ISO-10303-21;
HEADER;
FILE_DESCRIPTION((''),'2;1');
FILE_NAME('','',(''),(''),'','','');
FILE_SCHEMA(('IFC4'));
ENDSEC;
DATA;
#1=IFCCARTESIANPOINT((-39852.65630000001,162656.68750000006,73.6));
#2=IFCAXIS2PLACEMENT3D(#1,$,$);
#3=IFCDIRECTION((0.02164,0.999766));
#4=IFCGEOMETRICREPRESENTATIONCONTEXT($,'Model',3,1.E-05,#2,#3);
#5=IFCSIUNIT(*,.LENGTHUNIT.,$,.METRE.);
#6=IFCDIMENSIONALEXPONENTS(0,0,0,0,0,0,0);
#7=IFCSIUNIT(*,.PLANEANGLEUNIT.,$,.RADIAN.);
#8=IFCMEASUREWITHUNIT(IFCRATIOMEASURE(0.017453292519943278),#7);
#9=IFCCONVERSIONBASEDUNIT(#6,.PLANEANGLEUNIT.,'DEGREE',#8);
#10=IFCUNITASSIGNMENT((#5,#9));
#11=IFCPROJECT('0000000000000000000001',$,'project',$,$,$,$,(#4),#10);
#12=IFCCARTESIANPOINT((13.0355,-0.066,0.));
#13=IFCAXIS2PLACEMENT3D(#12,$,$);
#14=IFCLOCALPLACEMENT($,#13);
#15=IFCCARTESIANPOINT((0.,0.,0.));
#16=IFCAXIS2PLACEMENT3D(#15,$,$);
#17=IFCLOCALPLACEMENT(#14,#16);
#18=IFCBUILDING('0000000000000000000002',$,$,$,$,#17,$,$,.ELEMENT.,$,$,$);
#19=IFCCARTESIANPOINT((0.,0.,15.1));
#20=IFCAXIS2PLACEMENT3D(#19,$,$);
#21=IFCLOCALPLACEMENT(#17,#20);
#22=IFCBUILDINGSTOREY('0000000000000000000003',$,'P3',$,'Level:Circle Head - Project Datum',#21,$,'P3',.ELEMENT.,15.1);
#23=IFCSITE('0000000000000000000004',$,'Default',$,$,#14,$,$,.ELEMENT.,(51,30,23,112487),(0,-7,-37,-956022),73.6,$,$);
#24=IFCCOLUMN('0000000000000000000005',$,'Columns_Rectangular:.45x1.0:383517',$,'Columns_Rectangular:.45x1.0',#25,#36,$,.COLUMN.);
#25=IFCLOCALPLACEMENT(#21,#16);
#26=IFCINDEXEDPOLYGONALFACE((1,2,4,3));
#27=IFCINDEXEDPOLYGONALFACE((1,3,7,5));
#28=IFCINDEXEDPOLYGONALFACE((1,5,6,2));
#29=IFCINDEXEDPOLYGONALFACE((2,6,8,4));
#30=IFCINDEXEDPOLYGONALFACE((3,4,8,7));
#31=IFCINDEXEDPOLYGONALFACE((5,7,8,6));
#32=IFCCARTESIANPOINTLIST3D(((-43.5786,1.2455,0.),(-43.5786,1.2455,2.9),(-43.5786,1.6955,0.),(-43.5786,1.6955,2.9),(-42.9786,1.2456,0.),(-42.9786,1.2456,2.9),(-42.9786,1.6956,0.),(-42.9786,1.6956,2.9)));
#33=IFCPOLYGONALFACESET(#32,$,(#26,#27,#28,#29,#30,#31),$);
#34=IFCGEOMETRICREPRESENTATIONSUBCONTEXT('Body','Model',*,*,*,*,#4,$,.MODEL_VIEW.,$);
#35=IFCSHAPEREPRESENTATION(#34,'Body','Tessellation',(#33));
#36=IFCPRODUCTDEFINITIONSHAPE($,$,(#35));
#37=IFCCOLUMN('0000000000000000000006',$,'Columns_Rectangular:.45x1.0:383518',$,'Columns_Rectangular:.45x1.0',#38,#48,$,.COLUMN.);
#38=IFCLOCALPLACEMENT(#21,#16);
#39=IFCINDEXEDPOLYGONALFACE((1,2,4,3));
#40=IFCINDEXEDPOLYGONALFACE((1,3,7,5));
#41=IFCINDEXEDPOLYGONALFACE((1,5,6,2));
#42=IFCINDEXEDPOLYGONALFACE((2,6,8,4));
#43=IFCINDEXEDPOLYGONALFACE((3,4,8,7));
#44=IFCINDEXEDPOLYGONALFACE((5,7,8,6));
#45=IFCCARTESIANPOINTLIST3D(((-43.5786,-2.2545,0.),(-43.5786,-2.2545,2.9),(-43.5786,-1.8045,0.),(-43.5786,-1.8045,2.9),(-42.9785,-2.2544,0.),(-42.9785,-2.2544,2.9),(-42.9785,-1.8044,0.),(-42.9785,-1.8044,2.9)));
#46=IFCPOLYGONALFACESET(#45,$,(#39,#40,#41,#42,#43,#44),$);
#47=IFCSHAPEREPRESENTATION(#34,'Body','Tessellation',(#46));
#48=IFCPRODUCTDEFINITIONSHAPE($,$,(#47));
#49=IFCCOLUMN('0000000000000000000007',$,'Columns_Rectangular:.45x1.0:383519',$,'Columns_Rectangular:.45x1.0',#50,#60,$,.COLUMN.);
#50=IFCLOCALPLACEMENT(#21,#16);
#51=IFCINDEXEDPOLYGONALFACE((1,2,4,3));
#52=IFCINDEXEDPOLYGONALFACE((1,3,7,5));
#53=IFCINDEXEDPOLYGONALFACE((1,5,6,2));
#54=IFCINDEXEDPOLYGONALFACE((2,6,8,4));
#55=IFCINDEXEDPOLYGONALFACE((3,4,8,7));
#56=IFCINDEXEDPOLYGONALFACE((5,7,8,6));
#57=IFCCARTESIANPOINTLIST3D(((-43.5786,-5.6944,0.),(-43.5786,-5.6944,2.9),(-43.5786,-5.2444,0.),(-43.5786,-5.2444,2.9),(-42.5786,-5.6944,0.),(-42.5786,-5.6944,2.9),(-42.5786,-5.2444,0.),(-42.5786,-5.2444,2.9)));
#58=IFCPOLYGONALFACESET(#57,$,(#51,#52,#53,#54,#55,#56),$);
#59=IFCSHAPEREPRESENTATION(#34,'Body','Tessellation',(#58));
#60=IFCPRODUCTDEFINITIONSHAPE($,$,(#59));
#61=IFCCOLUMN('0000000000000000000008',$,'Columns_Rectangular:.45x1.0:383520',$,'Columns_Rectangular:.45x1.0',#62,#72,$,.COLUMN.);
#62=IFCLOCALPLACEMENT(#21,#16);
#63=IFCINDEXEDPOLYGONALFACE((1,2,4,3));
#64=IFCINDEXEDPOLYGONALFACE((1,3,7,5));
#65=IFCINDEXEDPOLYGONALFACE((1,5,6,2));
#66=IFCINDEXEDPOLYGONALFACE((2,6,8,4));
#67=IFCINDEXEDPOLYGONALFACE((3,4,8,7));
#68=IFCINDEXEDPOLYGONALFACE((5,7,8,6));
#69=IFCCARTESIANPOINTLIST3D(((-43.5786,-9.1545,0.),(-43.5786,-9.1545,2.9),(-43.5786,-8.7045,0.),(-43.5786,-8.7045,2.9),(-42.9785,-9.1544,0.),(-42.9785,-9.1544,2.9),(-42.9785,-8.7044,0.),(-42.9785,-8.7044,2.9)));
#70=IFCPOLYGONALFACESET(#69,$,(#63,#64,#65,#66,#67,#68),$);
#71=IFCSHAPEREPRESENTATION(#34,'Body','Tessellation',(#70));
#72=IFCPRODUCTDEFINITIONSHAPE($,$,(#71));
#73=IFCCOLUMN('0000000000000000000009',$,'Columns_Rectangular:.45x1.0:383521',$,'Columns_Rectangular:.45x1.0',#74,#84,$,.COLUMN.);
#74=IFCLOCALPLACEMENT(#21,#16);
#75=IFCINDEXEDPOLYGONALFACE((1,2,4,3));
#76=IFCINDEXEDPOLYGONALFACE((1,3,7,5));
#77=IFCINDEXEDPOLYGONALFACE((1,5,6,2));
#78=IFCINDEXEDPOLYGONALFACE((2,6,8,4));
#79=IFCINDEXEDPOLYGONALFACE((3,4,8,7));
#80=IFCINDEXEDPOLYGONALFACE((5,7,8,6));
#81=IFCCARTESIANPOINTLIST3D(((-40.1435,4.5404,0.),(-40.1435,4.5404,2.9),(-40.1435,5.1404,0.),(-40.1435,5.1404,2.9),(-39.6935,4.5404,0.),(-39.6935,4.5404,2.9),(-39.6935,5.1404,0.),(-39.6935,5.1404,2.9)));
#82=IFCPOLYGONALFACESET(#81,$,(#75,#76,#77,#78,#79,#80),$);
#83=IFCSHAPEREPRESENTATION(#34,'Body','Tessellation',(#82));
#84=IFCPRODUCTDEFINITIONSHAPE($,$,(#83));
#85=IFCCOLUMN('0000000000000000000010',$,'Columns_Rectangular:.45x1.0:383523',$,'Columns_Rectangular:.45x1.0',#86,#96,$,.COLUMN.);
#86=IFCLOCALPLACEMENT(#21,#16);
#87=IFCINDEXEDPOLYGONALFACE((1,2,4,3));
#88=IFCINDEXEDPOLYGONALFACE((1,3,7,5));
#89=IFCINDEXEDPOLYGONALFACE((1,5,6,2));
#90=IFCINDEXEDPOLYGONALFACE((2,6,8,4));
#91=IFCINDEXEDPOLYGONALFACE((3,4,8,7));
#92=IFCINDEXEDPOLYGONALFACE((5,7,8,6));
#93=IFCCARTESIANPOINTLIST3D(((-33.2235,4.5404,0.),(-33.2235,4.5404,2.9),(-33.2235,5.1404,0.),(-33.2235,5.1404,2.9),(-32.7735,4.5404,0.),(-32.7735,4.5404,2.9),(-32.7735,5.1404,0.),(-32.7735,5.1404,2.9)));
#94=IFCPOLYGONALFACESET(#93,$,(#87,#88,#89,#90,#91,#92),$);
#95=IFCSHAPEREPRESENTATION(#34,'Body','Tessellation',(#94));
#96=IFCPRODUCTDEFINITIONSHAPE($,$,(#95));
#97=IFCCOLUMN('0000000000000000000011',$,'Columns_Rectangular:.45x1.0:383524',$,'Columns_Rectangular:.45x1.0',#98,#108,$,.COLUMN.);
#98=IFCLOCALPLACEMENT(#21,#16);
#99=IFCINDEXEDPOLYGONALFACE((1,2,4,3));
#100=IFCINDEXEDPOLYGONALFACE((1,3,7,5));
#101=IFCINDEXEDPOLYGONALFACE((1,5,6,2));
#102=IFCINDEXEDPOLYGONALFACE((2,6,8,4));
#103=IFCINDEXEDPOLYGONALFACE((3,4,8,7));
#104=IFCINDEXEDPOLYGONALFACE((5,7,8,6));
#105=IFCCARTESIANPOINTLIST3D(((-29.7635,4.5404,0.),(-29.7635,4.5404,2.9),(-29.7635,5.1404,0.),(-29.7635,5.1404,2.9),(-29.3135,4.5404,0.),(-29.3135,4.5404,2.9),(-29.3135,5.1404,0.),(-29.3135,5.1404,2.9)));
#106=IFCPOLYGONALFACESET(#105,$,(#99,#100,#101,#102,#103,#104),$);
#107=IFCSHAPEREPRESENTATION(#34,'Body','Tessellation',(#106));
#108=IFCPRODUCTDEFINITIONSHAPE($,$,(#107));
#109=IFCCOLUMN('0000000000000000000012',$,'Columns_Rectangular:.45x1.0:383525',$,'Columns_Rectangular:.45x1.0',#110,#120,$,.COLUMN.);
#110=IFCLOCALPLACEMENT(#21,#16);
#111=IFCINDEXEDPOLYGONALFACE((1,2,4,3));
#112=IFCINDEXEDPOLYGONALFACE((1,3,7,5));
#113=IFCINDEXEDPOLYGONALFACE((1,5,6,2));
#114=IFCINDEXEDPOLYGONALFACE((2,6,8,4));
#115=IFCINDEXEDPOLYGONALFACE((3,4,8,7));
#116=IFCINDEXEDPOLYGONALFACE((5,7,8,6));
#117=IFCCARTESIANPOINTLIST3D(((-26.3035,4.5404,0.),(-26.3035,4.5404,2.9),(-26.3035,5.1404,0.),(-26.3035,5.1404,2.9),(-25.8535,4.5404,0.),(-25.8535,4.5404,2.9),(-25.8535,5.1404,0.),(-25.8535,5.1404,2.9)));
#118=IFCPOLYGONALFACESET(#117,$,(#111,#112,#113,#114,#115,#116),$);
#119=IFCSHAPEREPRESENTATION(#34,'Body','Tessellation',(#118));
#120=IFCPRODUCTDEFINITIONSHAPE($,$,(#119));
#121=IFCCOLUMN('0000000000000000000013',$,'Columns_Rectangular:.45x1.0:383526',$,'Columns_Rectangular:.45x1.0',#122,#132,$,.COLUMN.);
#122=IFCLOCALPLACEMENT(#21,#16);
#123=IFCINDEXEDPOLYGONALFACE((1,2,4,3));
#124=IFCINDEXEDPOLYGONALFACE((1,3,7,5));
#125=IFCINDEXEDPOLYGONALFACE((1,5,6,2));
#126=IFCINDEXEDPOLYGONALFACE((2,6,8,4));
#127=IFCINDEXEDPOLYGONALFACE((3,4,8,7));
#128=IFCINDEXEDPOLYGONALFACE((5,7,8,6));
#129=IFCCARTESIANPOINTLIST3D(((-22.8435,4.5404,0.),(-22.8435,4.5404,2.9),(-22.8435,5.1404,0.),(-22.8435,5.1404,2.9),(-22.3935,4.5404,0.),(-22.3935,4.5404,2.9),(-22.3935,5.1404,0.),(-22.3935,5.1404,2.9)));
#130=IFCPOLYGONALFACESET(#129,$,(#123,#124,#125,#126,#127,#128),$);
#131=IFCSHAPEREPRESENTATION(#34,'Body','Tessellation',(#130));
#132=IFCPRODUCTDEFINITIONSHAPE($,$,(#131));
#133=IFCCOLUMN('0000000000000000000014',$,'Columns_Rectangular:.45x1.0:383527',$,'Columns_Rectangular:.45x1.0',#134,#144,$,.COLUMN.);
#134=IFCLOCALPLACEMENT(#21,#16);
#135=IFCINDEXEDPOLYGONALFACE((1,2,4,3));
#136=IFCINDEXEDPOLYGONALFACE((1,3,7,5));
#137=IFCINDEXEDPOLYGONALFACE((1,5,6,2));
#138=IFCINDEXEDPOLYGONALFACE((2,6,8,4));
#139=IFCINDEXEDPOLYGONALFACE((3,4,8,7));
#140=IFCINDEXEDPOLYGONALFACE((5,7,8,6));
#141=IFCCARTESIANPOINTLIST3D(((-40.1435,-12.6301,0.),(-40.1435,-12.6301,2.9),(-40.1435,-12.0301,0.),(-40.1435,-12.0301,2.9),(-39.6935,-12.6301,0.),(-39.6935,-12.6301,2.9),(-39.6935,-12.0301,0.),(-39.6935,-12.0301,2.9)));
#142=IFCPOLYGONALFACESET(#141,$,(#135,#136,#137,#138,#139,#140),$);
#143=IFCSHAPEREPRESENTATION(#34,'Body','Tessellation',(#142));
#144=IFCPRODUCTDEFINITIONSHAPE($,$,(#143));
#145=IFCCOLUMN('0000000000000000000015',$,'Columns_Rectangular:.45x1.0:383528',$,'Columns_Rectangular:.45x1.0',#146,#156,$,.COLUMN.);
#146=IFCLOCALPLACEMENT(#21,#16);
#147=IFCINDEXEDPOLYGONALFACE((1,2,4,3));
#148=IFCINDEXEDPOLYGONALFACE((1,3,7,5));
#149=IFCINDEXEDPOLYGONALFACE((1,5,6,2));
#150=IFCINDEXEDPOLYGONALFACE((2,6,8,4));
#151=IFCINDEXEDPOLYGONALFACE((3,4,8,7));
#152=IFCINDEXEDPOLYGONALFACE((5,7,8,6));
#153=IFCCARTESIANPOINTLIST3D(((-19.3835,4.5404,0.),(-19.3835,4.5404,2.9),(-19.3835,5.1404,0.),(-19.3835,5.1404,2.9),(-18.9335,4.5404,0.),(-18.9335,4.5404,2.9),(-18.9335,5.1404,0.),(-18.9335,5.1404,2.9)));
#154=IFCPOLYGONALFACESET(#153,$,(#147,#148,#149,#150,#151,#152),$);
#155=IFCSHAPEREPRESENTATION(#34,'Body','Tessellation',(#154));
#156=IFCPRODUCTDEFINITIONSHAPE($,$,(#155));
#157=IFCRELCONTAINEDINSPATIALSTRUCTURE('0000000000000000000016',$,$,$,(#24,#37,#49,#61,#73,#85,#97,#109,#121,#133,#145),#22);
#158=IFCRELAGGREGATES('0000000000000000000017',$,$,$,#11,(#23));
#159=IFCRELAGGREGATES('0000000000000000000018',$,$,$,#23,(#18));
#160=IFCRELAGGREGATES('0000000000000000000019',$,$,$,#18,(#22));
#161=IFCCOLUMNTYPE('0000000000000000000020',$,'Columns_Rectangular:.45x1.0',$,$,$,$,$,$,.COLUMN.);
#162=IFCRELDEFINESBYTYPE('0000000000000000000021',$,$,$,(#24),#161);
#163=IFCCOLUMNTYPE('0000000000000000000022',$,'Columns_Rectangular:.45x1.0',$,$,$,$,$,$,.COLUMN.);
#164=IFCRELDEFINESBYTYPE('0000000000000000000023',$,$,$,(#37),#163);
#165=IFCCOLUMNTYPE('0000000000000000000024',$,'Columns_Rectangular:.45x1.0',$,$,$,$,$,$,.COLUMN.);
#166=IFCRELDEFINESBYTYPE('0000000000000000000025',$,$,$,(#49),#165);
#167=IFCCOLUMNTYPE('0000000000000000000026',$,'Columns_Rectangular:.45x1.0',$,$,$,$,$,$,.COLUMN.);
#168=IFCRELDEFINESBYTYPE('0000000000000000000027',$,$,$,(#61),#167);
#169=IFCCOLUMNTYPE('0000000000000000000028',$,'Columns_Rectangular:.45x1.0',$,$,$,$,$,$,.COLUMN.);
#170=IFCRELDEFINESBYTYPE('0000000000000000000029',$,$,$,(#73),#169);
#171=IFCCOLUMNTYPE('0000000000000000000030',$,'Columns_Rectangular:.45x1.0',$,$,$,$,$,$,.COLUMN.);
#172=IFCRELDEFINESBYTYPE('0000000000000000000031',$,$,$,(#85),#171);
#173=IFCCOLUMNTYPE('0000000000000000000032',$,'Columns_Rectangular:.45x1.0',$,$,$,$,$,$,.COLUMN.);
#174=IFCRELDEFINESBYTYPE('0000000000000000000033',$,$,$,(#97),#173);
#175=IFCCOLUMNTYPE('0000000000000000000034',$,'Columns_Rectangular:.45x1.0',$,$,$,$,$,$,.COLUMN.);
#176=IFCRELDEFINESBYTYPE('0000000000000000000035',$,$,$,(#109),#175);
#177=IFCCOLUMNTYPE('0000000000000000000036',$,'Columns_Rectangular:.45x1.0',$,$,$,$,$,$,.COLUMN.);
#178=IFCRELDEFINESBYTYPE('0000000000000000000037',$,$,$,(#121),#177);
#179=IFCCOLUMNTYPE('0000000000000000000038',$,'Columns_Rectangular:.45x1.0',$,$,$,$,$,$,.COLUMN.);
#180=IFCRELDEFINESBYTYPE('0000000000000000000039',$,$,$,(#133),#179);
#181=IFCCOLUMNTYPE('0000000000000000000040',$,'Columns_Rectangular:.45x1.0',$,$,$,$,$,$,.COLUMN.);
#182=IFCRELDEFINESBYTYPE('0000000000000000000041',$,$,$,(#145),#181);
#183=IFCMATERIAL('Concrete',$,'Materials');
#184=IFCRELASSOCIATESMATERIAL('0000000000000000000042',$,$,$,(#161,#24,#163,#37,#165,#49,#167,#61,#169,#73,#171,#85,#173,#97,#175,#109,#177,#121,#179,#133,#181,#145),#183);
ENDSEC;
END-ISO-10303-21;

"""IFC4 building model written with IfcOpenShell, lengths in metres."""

from ifc_helpers import new_model, entity, si_unit, converted_unit, direction, frame, origin, place, context, subcontext, project, spatial, indexed_curve, outline, extrude, source, transform, mapped, material, type_object, type_shapes, element, save


model = new_model("IFC4")

# Units and contexts
model_context = context("Model", 3, precision=1e-05, world=frame((-39852.65630000001, 162656.68750000006, 73.6)), true_north=direction((0.02164, 0.999766)))
body_context = subcontext(model_context, "Body", "Model", "MODEL_VIEW")
ifc_project = project(units=[si_unit("LENGTHUNIT", "METRE"), converted_unit("PLANEANGLEUNIT", "DEGREE", entity("IfcRatioMeasure", 0.017453292519943278), si_unit("PLANEANGLEUNIT", "RADIAN"), dimensions=[0, 0, 0, 0, 0, 0, 0])], contexts=[model_context])

# Site, building, storey
site_placement = place(None, frame((13.0355, -0.066, 0.0)))
site = spatial("IfcSite", under=ifc_project, at=site_placement, Name="Default", CompositionType="ELEMENT", RefLatitude=(51, 30, 23, 112487), RefLongitude=(0, -7, -37, -956022), RefElevation=73.6)
building_placement = place(site_placement, origin())
building = spatial("IfcBuilding", under=site, at=building_placement, CompositionType="ELEMENT")
storey_placement = place(building_placement, frame((0.0, 0.0, 15.1)))
storey = spatial("IfcBuildingStorey", under=building, at=storey_placement, Name="P3", ObjectType="Level:Circle Head - Project Datum", LongName="P3", CompositionType="ELEMENT", Elevation=15.1)

# Columns
ifc_material = material(Name="Concrete", Category="Materials")
column_type_1 = type_object("IfcColumnType", Name="Columns_Rectangular:.45x1.0", PredefinedType="COLUMN", material=ifc_material)
shared_shape_1 = source(origin(), body_context, "Body", "SweptSolid", [
    extrude(outline(indexed_curve([(-0.3, -0.225), (0.3, -0.225), (0.3, 0.225), (-0.3, 0.225), (-0.3, -0.225)], self_intersect=False)), frame((-43.2786, 1.4706, 15.1), z_axis=(0.0, 0.0, 1.0), x_axis=(-1.0, -0.000005, 0.0)), (0.0, 0.0, 1.0), 2.9),
])
type_shapes(column_type_1, [shared_shape_1])
column_1_placement = place(storey_placement, frame((0.0, 0.0, -15.1)))
element("IfcColumn", 1, at=column_1_placement, inside=storey, type_object=column_type_1, material=ifc_material, Name="Columns_Rectangular:.45x1.0:383517", ObjectType="Columns_Rectangular:.45x1.0", PredefinedType="COLUMN", context=body_context, shape_type="MappedRepresentation", body=[
    mapped(shared_shape_1, transform((0.0, 0.0, 0.0), scale=1.0)),
])
column_type_2 = type_object("IfcColumnType", Name="Columns_Rectangular:.45x1.0", PredefinedType="COLUMN", material=ifc_material)
shared_shape_2 = source(origin(), body_context, "Body", "SweptSolid", [
    extrude(outline(indexed_curve([(-0.3, -0.225), (0.3, -0.225), (0.3, 0.225), (-0.3, 0.225), (-0.3, -0.225)], self_intersect=False)), frame((-43.2785, -2.0294, 15.1), z_axis=(0.0, 0.0, 1.0), x_axis=(-1.0, -0.000005, 0.0)), (0.0, 0.0, 1.0), 2.9),
])
type_shapes(column_type_2, [shared_shape_2])
column_2_placement = place(storey_placement, frame((0.0, 0.0, -15.1)))
element("IfcColumn", 2, at=column_2_placement, inside=storey, type_object=column_type_2, material=ifc_material, Name="Columns_Rectangular:.45x1.0:383518", ObjectType="Columns_Rectangular:.45x1.0", PredefinedType="COLUMN", context=body_context, shape_type="MappedRepresentation", body=[
    mapped(shared_shape_2, transform((0.0, 0.0, 0.0), scale=1.0)),
])
column_type_3 = type_object("IfcColumnType", Name="Columns_Rectangular:.45x1.0", PredefinedType="COLUMN", material=ifc_material)
shared_shape_3 = source(origin(), body_context, "Body", "SweptSolid", [
    extrude(outline(indexed_curve([(-0.225, -0.5), (0.225, -0.5), (0.225, 0.5), (-0.225, 0.5), (-0.225, -0.5)], self_intersect=False)), frame((-43.0786, -5.4694, 15.1), z_axis=(0.0, 0.0, 1.0), x_axis=(0.0, -1.0, 0.0)), (0.0, 0.0, 1.0), 2.9),
])
type_shapes(column_type_3, [shared_shape_3])
column_3_placement = place(storey_placement, frame((0.0, 0.0, -15.1)))
element("IfcColumn", 3, at=column_3_placement, inside=storey, type_object=column_type_3, material=ifc_material, Name="Columns_Rectangular:.45x1.0:383519", ObjectType="Columns_Rectangular:.45x1.0", PredefinedType="COLUMN", context=body_context, shape_type="MappedRepresentation", body=[
    mapped(shared_shape_3, transform((0.0, 0.0, 0.0), scale=1.0)),
])
column_type_4 = type_object("IfcColumnType", Name="Columns_Rectangular:.45x1.0", PredefinedType="COLUMN", material=ifc_material)
shared_shape_4 = source(origin(), body_context, "Body", "SweptSolid", [
    extrude(outline(indexed_curve([(-0.3, -0.225), (0.3, -0.225), (0.3, 0.225), (-0.3, 0.225), (-0.3, -0.225)], self_intersect=False)), frame((-43.2785, -8.9294, 15.1), z_axis=(0.0, 0.0, 1.0), x_axis=(-1.0, -0.000005, 0.0)), (0.0, 0.0, 1.0), 2.9),
])
type_shapes(column_type_4, [shared_shape_4])
column_4_placement = place(storey_placement, frame((0.0, 0.0, -15.1)))
element("IfcColumn", 4, at=column_4_placement, inside=storey, type_object=column_type_4, material=ifc_material, Name="Columns_Rectangular:.45x1.0:383520", ObjectType="Columns_Rectangular:.45x1.0", PredefinedType="COLUMN", context=body_context, shape_type="MappedRepresentation", body=[
    mapped(shared_shape_4, transform((0.0, 0.0, 0.0), scale=1.0)),
])
column_type_5 = type_object("IfcColumnType", Name="Columns_Rectangular:.45x1.0", PredefinedType="COLUMN", material=ifc_material)
shared_shape_5 = source(origin(), body_context, "Body", "SweptSolid", [
    extrude(outline(indexed_curve([(-0.3, -0.225), (0.3, -0.225), (0.3, 0.225), (-0.3, 0.225), (-0.3, -0.225)], self_intersect=False)), frame((-39.9185, 4.8404, 15.1), z_axis=(0.0, 0.0, 1.0), x_axis=(0.0, -1.0, 0.0)), (0.0, 0.0, 1.0), 2.9),
])
type_shapes(column_type_5, [shared_shape_5])
column_5_placement = place(storey_placement, frame((0.0, 0.0, -15.1)))
element("IfcColumn", 5, at=column_5_placement, inside=storey, type_object=column_type_5, material=ifc_material, Name="Columns_Rectangular:.45x1.0:383521", ObjectType="Columns_Rectangular:.45x1.0", PredefinedType="COLUMN", context=body_context, shape_type="MappedRepresentation", body=[
    mapped(shared_shape_5, transform((0.0, 0.0, 0.0), scale=1.0)),
])
column_type_6 = type_object("IfcColumnType", Name="Columns_Rectangular:.45x1.0", PredefinedType="COLUMN", material=ifc_material)
shared_shape_6 = source(origin(), body_context, "Body", "SweptSolid", [
    extrude(outline(indexed_curve([(-0.3, -0.225), (0.3, -0.225), (0.3, 0.225), (-0.3, 0.225), (-0.3, -0.225)], self_intersect=False)), frame((-32.9985, 4.8404, 15.1), z_axis=(0.0, 0.0, 1.0), x_axis=(0.0, -1.0, 0.0)), (0.0, 0.0, 1.0), 2.9),
])
type_shapes(column_type_6, [shared_shape_6])
column_6_placement = place(storey_placement, frame((0.0, 0.0, -15.1)))
element("IfcColumn", 6, at=column_6_placement, inside=storey, type_object=column_type_6, material=ifc_material, Name="Columns_Rectangular:.45x1.0:383523", ObjectType="Columns_Rectangular:.45x1.0", PredefinedType="COLUMN", context=body_context, shape_type="MappedRepresentation", body=[
    mapped(shared_shape_6, transform((0.0, 0.0, 0.0), scale=1.0)),
])
column_type_7 = type_object("IfcColumnType", Name="Columns_Rectangular:.45x1.0", PredefinedType="COLUMN", material=ifc_material)
shared_shape_7 = source(origin(), body_context, "Body", "SweptSolid", [
    extrude(outline(indexed_curve([(-0.3, -0.225), (0.3, -0.225), (0.3, 0.225), (-0.3, 0.225), (-0.3, -0.225)], self_intersect=False)), frame((-29.5385, 4.8404, 15.1), z_axis=(0.0, 0.0, 1.0), x_axis=(0.0, -1.0, 0.0)), (0.0, 0.0, 1.0), 2.9),
])
type_shapes(column_type_7, [shared_shape_7])
column_7_placement = place(storey_placement, frame((0.0, 0.0, -15.1)))
element("IfcColumn", 7, at=column_7_placement, inside=storey, type_object=column_type_7, material=ifc_material, Name="Columns_Rectangular:.45x1.0:383524", ObjectType="Columns_Rectangular:.45x1.0", PredefinedType="COLUMN", context=body_context, shape_type="MappedRepresentation", body=[
    mapped(shared_shape_7, transform((0.0, 0.0, 0.0), scale=1.0)),
])
column_type_8 = type_object("IfcColumnType", Name="Columns_Rectangular:.45x1.0", PredefinedType="COLUMN", material=ifc_material)
shared_shape_8 = source(origin(), body_context, "Body", "SweptSolid", [
    extrude(outline(indexed_curve([(-0.3, -0.225), (0.3, -0.225), (0.3, 0.225), (-0.3, 0.225), (-0.3, -0.225)], self_intersect=False)), frame((-26.0785, 4.8404, 15.1), z_axis=(0.0, 0.0, 1.0), x_axis=(0.0, -1.0, 0.0)), (0.0, 0.0, 1.0), 2.9),
])
type_shapes(column_type_8, [shared_shape_8])
column_8_placement = place(storey_placement, frame((0.0, 0.0, -15.1)))
element("IfcColumn", 8, at=column_8_placement, inside=storey, type_object=column_type_8, material=ifc_material, Name="Columns_Rectangular:.45x1.0:383525", ObjectType="Columns_Rectangular:.45x1.0", PredefinedType="COLUMN", context=body_context, shape_type="MappedRepresentation", body=[
    mapped(shared_shape_8, transform((0.0, 0.0, 0.0), scale=1.0)),
])
column_type_9 = type_object("IfcColumnType", Name="Columns_Rectangular:.45x1.0", PredefinedType="COLUMN", material=ifc_material)
shared_shape_9 = source(origin(), body_context, "Body", "SweptSolid", [
    extrude(outline(indexed_curve([(-0.3, -0.225), (0.3, -0.225), (0.3, 0.225), (-0.3, 0.225), (-0.3, -0.225)], self_intersect=False)), frame((-22.6185, 4.8404, 15.1), z_axis=(0.0, 0.0, 1.0), x_axis=(0.0, -1.0, 0.0)), (0.0, 0.0, 1.0), 2.9),
])
type_shapes(column_type_9, [shared_shape_9])
column_9_placement = place(storey_placement, frame((0.0, 0.0, -15.1)))
element("IfcColumn", 9, at=column_9_placement, inside=storey, type_object=column_type_9, material=ifc_material, Name="Columns_Rectangular:.45x1.0:383526", ObjectType="Columns_Rectangular:.45x1.0", PredefinedType="COLUMN", context=body_context, shape_type="MappedRepresentation", body=[
    mapped(shared_shape_9, transform((0.0, 0.0, 0.0), scale=1.0)),
])
column_type_10 = type_object("IfcColumnType", Name="Columns_Rectangular:.45x1.0", PredefinedType="COLUMN", material=ifc_material)
shared_shape_10 = source(origin(), body_context, "Body", "SweptSolid", [
    extrude(outline(indexed_curve([(-0.3, -0.225), (0.3, -0.225), (0.3, 0.225), (-0.3, 0.225), (-0.3, -0.225)], self_intersect=False)), frame((-39.9185, -12.3301, 15.1), z_axis=(0.0, 0.0, 1.0), x_axis=(0.000011, 1.0, 0.0)), (0.0, 0.0, 1.0), 2.9),
])
type_shapes(column_type_10, [shared_shape_10])
column_10_placement = place(storey_placement, frame((0.0, 0.0, -15.1)))
element("IfcColumn", 10, at=column_10_placement, inside=storey, type_object=column_type_10, material=ifc_material, Name="Columns_Rectangular:.45x1.0:383527", ObjectType="Columns_Rectangular:.45x1.0", PredefinedType="COLUMN", context=body_context, shape_type="MappedRepresentation", body=[
    mapped(shared_shape_10, transform((0.0, 0.0, 0.0), scale=1.0)),
])
column_type_11 = type_object("IfcColumnType", Name="Columns_Rectangular:.45x1.0", PredefinedType="COLUMN", material=ifc_material)
shared_shape_11 = source(origin(), body_context, "Body", "SweptSolid", [
    extrude(outline(indexed_curve([(-0.3, -0.225), (0.3, -0.225), (0.3, 0.225), (-0.3, 0.225), (-0.3, -0.225)], self_intersect=False)), frame((-19.1585, 4.8404, 15.1), z_axis=(0.0, 0.0, 1.0), x_axis=(0.0, -1.0, 0.0)), (0.0, 0.0, 1.0), 2.9),
])
type_shapes(column_type_11, [shared_shape_11])
column_11_placement = place(storey_placement, frame((0.0, 0.0, -15.1)))
element("IfcColumn", 11, at=column_11_placement, inside=storey, type_object=column_type_11, material=ifc_material, Name="Columns_Rectangular:.45x1.0:383528", ObjectType="Columns_Rectangular:.45x1.0", PredefinedType="COLUMN", context=body_context, shape_type="MappedRepresentation", body=[
    mapped(shared_shape_11, transform((0.0, 0.0, 0.0), scale=1.0)),
])

save(model, "model.ifc")
